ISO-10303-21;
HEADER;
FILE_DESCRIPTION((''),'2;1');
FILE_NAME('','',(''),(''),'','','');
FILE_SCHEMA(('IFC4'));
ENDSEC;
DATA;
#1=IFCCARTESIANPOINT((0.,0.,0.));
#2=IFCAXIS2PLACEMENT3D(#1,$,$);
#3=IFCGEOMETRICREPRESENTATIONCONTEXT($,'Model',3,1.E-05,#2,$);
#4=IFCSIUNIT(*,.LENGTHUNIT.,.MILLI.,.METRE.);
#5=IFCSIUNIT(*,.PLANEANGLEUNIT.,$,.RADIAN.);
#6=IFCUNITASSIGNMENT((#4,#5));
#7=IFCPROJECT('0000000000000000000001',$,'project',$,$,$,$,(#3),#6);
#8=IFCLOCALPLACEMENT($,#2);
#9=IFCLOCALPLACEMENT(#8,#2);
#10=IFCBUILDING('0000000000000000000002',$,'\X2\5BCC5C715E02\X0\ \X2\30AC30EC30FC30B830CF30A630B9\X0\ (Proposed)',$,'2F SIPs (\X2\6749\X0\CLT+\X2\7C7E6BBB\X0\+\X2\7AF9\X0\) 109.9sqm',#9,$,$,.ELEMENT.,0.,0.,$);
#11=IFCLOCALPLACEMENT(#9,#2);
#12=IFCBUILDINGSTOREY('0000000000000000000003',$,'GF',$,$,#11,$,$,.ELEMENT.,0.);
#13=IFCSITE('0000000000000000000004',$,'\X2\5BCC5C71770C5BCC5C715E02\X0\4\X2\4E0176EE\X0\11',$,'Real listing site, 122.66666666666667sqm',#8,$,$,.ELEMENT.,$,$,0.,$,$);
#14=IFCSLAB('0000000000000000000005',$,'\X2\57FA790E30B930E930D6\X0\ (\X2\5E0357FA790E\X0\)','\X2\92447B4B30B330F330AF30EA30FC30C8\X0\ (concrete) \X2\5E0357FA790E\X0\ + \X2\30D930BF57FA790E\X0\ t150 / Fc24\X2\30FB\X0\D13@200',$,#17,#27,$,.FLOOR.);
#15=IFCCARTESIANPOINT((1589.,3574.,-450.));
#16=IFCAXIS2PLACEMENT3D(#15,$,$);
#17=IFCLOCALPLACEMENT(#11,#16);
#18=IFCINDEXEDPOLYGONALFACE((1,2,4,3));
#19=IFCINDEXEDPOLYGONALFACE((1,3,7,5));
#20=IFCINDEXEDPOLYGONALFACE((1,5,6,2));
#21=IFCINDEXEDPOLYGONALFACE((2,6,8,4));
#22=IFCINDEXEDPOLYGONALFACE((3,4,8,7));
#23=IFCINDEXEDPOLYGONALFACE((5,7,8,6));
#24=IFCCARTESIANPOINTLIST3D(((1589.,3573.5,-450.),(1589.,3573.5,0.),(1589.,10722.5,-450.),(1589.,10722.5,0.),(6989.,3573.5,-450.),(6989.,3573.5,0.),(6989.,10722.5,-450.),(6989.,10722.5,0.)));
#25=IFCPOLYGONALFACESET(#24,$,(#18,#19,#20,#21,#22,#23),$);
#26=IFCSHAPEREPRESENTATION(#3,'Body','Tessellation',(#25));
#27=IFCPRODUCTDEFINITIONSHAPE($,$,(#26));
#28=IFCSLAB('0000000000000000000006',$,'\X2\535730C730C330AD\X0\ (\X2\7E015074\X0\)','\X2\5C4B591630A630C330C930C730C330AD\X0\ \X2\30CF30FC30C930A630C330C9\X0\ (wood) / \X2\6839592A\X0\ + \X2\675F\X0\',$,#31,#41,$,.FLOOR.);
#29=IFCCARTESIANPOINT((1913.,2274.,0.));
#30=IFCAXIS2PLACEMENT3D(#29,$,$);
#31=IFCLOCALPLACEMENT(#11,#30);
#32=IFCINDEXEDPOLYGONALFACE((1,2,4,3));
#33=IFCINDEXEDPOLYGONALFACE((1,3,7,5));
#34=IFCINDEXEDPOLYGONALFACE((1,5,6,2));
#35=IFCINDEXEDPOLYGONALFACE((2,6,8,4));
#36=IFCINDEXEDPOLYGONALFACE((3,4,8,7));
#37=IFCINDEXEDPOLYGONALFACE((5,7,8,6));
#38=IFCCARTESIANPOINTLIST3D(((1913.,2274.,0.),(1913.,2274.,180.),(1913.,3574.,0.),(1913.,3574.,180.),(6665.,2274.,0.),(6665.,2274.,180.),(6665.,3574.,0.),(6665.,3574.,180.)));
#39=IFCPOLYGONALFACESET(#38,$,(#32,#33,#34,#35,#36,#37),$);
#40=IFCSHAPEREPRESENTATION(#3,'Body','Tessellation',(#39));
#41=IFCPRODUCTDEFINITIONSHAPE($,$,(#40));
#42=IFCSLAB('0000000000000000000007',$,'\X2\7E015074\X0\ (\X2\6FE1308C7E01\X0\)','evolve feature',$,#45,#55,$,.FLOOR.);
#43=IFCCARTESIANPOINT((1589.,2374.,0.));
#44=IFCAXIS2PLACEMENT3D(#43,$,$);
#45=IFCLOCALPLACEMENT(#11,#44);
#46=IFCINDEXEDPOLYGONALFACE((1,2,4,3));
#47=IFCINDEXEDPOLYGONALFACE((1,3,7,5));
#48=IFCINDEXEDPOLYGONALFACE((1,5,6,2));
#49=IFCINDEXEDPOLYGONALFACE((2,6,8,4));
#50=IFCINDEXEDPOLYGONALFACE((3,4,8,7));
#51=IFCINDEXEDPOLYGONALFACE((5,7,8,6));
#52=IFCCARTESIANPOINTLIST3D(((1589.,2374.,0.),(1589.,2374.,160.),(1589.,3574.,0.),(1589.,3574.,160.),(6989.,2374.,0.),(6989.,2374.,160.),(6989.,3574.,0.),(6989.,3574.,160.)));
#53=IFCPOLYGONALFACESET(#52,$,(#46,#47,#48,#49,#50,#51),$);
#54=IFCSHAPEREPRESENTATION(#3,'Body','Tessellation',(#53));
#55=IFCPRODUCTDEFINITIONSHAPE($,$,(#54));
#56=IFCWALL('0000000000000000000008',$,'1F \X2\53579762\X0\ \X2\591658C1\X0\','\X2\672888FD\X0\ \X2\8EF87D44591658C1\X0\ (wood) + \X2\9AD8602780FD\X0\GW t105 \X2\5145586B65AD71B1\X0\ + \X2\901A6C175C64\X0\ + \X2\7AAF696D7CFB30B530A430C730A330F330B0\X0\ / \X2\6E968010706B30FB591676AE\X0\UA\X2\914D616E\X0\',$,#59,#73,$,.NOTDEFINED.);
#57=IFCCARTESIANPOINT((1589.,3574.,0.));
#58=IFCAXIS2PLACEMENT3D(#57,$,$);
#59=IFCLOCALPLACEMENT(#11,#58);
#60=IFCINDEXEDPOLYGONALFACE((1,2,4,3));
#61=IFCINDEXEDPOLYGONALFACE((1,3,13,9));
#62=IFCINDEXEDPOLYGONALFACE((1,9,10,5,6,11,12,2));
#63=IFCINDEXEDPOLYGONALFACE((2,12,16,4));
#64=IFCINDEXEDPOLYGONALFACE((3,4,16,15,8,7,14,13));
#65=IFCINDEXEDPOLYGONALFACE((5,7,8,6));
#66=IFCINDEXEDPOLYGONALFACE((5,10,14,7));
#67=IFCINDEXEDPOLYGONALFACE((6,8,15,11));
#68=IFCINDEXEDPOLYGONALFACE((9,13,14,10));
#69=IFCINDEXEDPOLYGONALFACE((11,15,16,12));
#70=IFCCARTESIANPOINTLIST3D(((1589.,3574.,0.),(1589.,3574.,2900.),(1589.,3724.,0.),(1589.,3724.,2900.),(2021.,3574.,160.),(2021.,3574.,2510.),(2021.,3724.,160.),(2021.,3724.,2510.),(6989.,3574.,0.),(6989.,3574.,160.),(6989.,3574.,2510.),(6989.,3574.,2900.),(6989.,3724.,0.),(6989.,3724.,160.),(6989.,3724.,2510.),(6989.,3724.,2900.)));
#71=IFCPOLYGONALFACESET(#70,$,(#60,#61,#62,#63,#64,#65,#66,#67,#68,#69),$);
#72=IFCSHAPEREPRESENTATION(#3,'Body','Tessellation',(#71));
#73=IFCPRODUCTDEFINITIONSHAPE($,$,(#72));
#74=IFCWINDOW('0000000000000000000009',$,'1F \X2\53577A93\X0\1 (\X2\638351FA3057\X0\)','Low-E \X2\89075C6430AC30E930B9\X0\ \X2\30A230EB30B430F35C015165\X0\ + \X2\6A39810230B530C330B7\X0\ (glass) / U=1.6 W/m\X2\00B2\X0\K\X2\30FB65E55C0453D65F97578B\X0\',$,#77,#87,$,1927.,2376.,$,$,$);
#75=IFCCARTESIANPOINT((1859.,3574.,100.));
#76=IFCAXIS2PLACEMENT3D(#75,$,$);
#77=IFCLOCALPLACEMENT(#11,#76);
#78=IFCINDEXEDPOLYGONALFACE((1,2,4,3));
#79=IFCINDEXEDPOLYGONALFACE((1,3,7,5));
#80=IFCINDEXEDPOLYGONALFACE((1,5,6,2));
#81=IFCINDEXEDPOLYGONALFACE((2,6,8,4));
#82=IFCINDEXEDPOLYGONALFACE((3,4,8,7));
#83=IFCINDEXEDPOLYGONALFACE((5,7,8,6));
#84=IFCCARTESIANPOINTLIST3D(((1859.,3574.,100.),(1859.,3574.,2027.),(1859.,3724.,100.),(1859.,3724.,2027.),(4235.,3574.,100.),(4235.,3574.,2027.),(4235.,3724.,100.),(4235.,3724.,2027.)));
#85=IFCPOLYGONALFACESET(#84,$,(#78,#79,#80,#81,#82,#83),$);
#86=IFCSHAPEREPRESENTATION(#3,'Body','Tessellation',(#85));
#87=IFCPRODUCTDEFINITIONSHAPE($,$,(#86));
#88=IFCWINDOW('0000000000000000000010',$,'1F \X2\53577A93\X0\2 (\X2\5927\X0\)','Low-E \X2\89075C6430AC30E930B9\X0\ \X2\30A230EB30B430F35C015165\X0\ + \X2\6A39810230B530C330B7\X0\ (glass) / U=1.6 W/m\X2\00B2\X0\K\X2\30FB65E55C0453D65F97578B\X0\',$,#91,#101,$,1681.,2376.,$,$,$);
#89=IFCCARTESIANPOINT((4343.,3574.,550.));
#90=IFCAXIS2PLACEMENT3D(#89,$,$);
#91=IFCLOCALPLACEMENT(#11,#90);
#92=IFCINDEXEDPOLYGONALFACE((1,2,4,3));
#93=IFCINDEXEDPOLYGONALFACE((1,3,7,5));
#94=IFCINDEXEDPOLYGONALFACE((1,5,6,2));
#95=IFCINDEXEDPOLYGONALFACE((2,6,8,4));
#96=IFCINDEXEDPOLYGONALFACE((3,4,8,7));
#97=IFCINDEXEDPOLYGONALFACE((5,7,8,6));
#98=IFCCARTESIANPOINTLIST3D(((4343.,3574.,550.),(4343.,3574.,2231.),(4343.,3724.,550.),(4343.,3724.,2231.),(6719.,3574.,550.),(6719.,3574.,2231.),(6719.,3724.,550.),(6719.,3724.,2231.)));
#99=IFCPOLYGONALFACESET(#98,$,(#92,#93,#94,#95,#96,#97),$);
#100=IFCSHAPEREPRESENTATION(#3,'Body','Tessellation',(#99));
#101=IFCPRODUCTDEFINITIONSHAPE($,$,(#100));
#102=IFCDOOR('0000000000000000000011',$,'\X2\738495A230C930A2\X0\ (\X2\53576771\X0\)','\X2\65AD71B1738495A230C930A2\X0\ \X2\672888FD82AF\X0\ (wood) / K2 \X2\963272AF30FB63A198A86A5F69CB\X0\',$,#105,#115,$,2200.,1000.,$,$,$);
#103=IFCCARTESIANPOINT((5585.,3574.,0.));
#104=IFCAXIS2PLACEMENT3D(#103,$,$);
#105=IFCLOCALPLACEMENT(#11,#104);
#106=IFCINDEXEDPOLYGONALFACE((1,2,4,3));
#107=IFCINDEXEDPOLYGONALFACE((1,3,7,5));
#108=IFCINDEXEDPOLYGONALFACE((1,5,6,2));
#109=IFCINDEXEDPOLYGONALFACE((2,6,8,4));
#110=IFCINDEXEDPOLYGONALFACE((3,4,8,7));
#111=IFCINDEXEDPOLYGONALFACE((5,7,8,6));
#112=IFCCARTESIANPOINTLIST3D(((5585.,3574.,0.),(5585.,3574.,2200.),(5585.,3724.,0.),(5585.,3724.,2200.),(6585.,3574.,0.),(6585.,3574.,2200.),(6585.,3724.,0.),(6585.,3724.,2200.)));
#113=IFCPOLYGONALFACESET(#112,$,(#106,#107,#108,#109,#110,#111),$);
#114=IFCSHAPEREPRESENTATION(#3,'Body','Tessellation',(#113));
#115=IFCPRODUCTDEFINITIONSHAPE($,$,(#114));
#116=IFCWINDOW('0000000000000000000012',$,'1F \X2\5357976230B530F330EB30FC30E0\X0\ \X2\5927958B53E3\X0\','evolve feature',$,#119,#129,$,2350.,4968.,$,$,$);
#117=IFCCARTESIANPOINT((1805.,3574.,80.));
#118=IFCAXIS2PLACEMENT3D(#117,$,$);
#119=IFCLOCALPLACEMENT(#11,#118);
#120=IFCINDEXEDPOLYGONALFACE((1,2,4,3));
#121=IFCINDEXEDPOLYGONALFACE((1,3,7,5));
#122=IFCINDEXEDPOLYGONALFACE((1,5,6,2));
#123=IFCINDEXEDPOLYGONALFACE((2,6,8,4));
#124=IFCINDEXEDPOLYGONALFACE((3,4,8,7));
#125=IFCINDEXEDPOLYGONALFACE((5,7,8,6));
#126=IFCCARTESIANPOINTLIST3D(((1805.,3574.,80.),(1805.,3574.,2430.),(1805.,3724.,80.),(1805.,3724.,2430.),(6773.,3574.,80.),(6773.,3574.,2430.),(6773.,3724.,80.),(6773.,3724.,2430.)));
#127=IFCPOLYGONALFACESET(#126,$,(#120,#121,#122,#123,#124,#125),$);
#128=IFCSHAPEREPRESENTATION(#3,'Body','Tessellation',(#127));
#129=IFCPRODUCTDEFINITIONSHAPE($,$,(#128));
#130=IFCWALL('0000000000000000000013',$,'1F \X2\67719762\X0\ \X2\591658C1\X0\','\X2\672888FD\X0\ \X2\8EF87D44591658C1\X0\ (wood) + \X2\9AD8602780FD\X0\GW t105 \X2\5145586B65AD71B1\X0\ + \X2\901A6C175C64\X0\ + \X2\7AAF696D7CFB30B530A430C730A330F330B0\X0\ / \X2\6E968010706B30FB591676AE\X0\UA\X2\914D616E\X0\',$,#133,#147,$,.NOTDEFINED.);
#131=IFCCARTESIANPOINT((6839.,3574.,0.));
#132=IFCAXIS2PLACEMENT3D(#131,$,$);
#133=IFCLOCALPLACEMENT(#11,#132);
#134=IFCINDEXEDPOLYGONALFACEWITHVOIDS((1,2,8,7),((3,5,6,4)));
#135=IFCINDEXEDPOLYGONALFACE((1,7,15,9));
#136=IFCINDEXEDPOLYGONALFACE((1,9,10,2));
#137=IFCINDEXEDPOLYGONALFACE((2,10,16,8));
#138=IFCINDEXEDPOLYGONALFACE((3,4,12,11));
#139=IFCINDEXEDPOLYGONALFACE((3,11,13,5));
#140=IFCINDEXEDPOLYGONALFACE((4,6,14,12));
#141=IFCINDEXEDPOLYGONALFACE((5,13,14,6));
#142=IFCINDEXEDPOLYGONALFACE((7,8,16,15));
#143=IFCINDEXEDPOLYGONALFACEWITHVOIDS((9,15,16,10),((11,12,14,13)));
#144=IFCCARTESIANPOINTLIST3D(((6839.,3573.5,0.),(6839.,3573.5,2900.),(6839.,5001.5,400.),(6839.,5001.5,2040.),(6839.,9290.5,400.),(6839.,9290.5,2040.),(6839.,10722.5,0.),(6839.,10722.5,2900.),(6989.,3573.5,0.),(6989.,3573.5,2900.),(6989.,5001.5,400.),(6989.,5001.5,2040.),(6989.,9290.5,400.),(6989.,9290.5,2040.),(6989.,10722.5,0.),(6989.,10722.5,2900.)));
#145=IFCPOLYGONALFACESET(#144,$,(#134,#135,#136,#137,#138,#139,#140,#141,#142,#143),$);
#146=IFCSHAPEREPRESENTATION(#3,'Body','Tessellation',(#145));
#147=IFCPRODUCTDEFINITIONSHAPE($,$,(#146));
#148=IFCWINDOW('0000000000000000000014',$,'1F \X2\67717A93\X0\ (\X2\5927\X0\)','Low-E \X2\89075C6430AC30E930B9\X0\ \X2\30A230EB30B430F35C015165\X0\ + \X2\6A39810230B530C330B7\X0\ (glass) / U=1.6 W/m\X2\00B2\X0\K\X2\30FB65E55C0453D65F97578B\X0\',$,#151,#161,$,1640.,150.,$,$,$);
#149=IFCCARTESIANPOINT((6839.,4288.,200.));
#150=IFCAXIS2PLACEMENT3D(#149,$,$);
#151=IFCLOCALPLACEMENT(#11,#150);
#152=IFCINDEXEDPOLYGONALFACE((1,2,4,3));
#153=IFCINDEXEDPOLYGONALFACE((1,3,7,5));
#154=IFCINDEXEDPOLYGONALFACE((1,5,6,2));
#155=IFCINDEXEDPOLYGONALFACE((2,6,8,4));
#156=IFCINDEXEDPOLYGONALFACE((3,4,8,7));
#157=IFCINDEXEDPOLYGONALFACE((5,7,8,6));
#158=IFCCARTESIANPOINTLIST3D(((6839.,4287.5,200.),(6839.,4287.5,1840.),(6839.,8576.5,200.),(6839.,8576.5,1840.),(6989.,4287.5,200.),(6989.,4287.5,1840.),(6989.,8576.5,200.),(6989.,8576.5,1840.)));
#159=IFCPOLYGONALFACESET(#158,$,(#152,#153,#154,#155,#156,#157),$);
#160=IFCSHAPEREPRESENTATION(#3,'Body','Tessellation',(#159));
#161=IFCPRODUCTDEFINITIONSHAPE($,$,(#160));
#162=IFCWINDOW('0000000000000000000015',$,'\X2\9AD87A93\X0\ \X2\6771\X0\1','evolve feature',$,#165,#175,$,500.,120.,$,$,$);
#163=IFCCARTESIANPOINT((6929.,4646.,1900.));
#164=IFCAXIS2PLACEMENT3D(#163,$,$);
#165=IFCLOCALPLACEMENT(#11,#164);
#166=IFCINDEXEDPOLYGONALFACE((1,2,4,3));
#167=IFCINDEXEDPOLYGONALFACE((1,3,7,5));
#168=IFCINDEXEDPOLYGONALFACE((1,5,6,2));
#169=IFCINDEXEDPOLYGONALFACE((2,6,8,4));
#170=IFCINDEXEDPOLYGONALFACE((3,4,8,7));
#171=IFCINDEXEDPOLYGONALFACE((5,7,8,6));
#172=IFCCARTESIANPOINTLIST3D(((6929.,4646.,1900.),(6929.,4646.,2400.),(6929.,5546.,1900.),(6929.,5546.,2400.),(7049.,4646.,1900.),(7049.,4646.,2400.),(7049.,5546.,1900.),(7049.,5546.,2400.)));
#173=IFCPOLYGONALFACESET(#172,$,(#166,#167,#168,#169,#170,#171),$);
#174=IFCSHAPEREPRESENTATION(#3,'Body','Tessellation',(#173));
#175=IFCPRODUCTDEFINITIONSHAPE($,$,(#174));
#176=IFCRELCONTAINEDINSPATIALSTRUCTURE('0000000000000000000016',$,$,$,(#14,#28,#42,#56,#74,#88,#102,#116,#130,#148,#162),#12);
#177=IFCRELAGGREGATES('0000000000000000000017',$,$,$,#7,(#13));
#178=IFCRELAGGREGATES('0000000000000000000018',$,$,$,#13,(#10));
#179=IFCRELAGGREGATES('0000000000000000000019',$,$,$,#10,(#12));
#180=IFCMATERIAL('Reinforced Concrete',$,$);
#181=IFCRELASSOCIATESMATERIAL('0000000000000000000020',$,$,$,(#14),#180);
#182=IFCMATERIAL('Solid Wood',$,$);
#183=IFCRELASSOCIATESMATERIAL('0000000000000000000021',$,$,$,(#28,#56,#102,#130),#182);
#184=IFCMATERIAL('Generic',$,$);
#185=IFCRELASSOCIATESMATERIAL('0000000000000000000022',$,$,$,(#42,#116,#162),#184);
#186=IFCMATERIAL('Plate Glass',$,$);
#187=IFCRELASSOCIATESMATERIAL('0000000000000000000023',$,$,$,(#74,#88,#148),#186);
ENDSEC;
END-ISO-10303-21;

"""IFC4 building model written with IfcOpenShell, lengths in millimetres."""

from ifc_helpers import new_model, si_unit, frame, frame_2d, origin, place, context, project, spatial, rectangle, extrude, material, element, fill, save


model = new_model("IFC4")

# Units and contexts
model_context = context("Model", 3, precision=1e-05, world=origin())
ifc_project = project(units=[si_unit("LENGTHUNIT", "METRE", prefix="MILLI"), si_unit("PLANEANGLEUNIT", "RADIAN")], contexts=[model_context])

# Site, building, storey
site_placement = place(None, origin())
site = spatial("IfcSite", under=ifc_project, at=site_placement, Name="富山県富山市4丁目11", ObjectType="Real listing site, 122.66666666666667sqm", CompositionType="ELEMENT", RefElevation=0.0)
building_placement = place(site_placement, origin())
building = spatial("IfcBuilding", under=site, at=building_placement, Name="富山市 ガレージハウス (Proposed)", ObjectType="2F SIPs (杉CLT+籾殻+竹) 109.9sqm", CompositionType="ELEMENT", ElevationOfRefHeight=0.0, ElevationOfTerrain=0.0)
storey_placement = place(building_placement, origin())
storey = spatial("IfcBuildingStorey", under=building, at=storey_placement, Name="GF", CompositionType="ELEMENT", Elevation=0.0)

# Slabs
ifc_material_1 = material(Name="Reinforced Concrete")
slab_1_placement = place(storey_placement, frame((1589.0, 3574.0, -450.0)))
element("IfcSlab", 1, at=slab_1_placement, inside=storey, material=ifc_material_1, Name="基礎スラブ (布基礎)", Description="鉄筋コンクリート (concrete) 布基礎 + ベタ基礎 t150 / Fc24・D13@200", PredefinedType="FLOOR", context=model_context, shape_type="SweptSolid", body=[
    extrude(rectangle(XDim=5400.0, YDim=7149.0, at=frame_2d((2700.0, 3574.0))), frame((1589.0, 3574.0, -450.0)), (0.0, 0.0, 1.0), 450.0),
])
ifc_material_2 = material(Name="Solid Wood")
slab_2_placement = place(storey_placement, frame((1913.0, 2274.0, 0.0)))
element("IfcSlab", 2, at=slab_2_placement, inside=storey, material=ifc_material_2, Name="南デッキ (縁側)", Description="屋外ウッドデッキ ハードウッド (wood) / 根太 + 束", PredefinedType="FLOOR", context=model_context, shape_type="SweptSolid", body=[
    extrude(rectangle(XDim=4752.0, YDim=1300.0, at=frame_2d((2376.0, 650.0))), frame((1913.0, 2274.0, 0.0)), (0.0, 0.0, 1.0), 180.0),
])
ifc_material_3 = material(Name="Generic")
slab_3_placement = place(storey_placement, frame((1589.0, 2374.0, 0.0)))
element("IfcSlab", 3, at=slab_3_placement, inside=storey, material=ifc_material_3, Name="縁側 (濡れ縁)", Description="evolve feature", PredefinedType="FLOOR", context=model_context, shape_type="SweptSolid", body=[
    extrude(rectangle(XDim=5400.0, YDim=1200.0, at=frame_2d((2700.0, 600.0))), frame((1589.0, 2374.0, 0.0)), (0.0, 0.0, 1.0), 160.0),
])

# Wall, openings, windows, door
wall_1_placement = place(storey_placement, frame((1589.0, 3574.0, 0.0)))
wall_1 = element("IfcWall", 4, at=wall_1_placement, inside=storey, material=ifc_material_2, Name="1F 南面 外壁", Description="木製 軸組外壁 (wood) + 高性能GW t105 充填断熱 + 通気層 + 窯業系サイディング / 準耐火・外皮UA配慮", PredefinedType="NOTDEFINED", context=model_context, shape_type="SweptSolid", body=[
    extrude(rectangle(XDim=5400.0, YDim=150.0, at=frame_2d((2700.0, 75.0))), frame((1589.0, 3574.0, 0.0)), (0.0, 0.0, 1.0), 2900.0),
])
opening_1_placement = place(storey_placement, frame((1859.0, 3574.0, 100.0)))
opening_1 = element("IfcOpeningElement", 5, at=opening_1_placement, cuts=wall_1, PredefinedType="NOTDEFINED", context=model_context, shape_type="SweptSolid", body=[
    extrude(rectangle(XDim=2376.0, YDim=150.0, at=frame_2d((1188.0, 75.0))), frame((1859.0, 3574.0, 100.0)), (0.0, 0.0, 1.0), 1927.0),
])
opening_2_placement = place(storey_placement, frame((4343.0, 3574.0, 550.0)))
opening_2 = element("IfcOpeningElement", 6, at=opening_2_placement, cuts=wall_1, PredefinedType="NOTDEFINED", context=model_context, shape_type="SweptSolid", body=[
    extrude(rectangle(XDim=2376.0, YDim=150.0, at=frame_2d((1188.0, 75.0))), frame((4343.0, 3574.0, 550.0)), (0.0, 0.0, 1.0), 1681.0),
])
opening_3_placement = place(storey_placement, frame((5585.0, 3574.0, 0.0)))
opening_3 = element("IfcOpeningElement", 7, at=opening_3_placement, cuts=wall_1, PredefinedType="NOTDEFINED", context=model_context, shape_type="SweptSolid", body=[
    extrude(rectangle(XDim=1000.0, YDim=150.0, at=frame_2d((500.0, 75.0))), frame((5585.0, 3574.0, 0.0)), (0.0, 0.0, 1.0), 2200.0),
])
opening_4_placement = place(storey_placement, frame((1805.0, 3574.0, 80.0)))
opening_4 = element("IfcOpeningElement", 8, at=opening_4_placement, cuts=wall_1, PredefinedType="NOTDEFINED", context=model_context, shape_type="SweptSolid", body=[
    extrude(rectangle(XDim=4968.0, YDim=150.0, at=frame_2d((2484.0, 75.0))), frame((1805.0, 3574.0, 80.0)), (0.0, 0.0, 1.0), 2350.0),
])
ifc_material_4 = material(Name="Plate Glass")
window_1_placement = place(storey_placement, frame((1859.0, 3574.0, 100.0)))
window_1 = element("IfcWindow", 9, at=window_1_placement, inside=storey, material=ifc_material_4, Name="1F 南窓1 (掃出し)", Description="Low-E 複層ガラス アルゴン封入 + 樹脂サッシ (glass) / U=1.6 W/m²K・日射取得型", OverallHeight=1927.0, OverallWidth=2376.0, context=model_context, shape_type="SweptSolid", body=[
    extrude(rectangle(XDim=2376.0, YDim=150.0, at=frame_2d((1188.0, 75.0))), frame((1859.0, 3574.0, 100.0)), (0.0, 0.0, 1.0), 1927.0),
])
fill(opening_1, window_1)
window_2_placement = place(storey_placement, frame((4343.0, 3574.0, 550.0)))
window_2 = element("IfcWindow", 10, at=window_2_placement, inside=storey, material=ifc_material_4, Name="1F 南窓2 (大)", Description="Low-E 複層ガラス アルゴン封入 + 樹脂サッシ (glass) / U=1.6 W/m²K・日射取得型", OverallHeight=1681.0, OverallWidth=2376.0, context=model_context, shape_type="SweptSolid", body=[
    extrude(rectangle(XDim=2376.0, YDim=150.0, at=frame_2d((1188.0, 75.0))), frame((4343.0, 3574.0, 550.0)), (0.0, 0.0, 1.0), 1681.0),
])
fill(opening_2, window_2)
door_placement = place(storey_placement, frame((5585.0, 3574.0, 0.0)))
door = element("IfcDoor", 11, at=door_placement, inside=storey, material=ifc_material_2, Name="玄関ドア (南東)", Description="断熱玄関ドア 木製芯 (wood) / K2 防犯・採風機構", OverallHeight=2200.0, OverallWidth=1000.0, context=model_context, shape_type="SweptSolid", body=[
    extrude(rectangle(XDim=1000.0, YDim=150.0, at=frame_2d((500.0, 75.0))), frame((5585.0, 3574.0, 0.0)), (0.0, 0.0, 1.0), 2200.0),
])
fill(opening_3, door)
window_3_placement = place(storey_placement, frame((1805.0, 3574.0, 80.0)))
window_3 = element("IfcWindow", 12, at=window_3_placement, inside=storey, material=ifc_material_3, Name="1F 南面サンルーム 大開口", Description="evolve feature", OverallHeight=2350.0, OverallWidth=4968.0, context=model_context, shape_type="SweptSolid", body=[
    extrude(rectangle(XDim=4968.0, YDim=150.0, at=frame_2d((2484.0, 75.0))), frame((1805.0, 3574.0, 80.0)), (0.0, 0.0, 1.0), 2350.0),
])
fill(opening_4, window_3)

# Wall, openings, windows
wall_2_placement = place(storey_placement, frame((6839.0, 3574.0, 0.0)))
wall_2 = element("IfcWall", 13, at=wall_2_placement, inside=storey, material=ifc_material_2, Name="1F 東面 外壁", Description="木製 軸組外壁 (wood) + 高性能GW t105 充填断熱 + 通気層 + 窯業系サイディング / 準耐火・外皮UA配慮", PredefinedType="NOTDEFINED", context=model_context, shape_type="SweptSolid", body=[
    extrude(rectangle(XDim=150.0, YDim=7149.0, at=frame_2d((75.0, 3574.0))), frame((6839.0, 3574.0, 0.0)), (0.0, 0.0, 1.0), 2900.0),
])
opening_5_placement = place(storey_placement, frame((6839.0, 4288.0, 200.0)))
opening_5 = element("IfcOpeningElement", 14, at=opening_5_placement, cuts=wall_2, PredefinedType="NOTDEFINED", context=model_context, shape_type="SweptSolid", body=[
    extrude(rectangle(XDim=150.0, YDim=4289.0, at=frame_2d((75.0, 2144.0))), frame((6839.0, 4288.0, 200.0)), (0.0, 0.0, 1.0), 1640.0),
])
opening_6_placement = place(storey_placement, frame((6929.0, 4646.0, 1900.0)))
opening_6 = element("IfcOpeningElement", 15, at=opening_6_placement, cuts=wall_2, PredefinedType="NOTDEFINED", context=model_context, shape_type="SweptSolid", body=[
    extrude(rectangle(XDim=120.0, YDim=900.0, at=frame_2d((60.0, 450.0))), frame((6929.0, 4646.0, 1900.0)), (0.0, 0.0, 1.0), 500.0),
])
window_4_placement = place(storey_placement, frame((6839.0, 4288.0, 200.0)))
window_4 = element("IfcWindow", 16, at=window_4_placement, inside=storey, material=ifc_material_4, Name="1F 東窓 (大)", Description="Low-E 複層ガラス アルゴン封入 + 樹脂サッシ (glass) / U=1.6 W/m²K・日射取得型", OverallHeight=1640.0, OverallWidth=150.0, context=model_context, shape_type="SweptSolid", body=[
    extrude(rectangle(XDim=150.0, YDim=4289.0, at=frame_2d((75.0, 2144.0))), frame((6839.0, 4288.0, 200.0)), (0.0, 0.0, 1.0), 1640.0),
])
fill(opening_5, window_4)
window_5_placement = place(storey_placement, frame((6929.0, 4646.0, 1900.0)))
window_5 = element("IfcWindow", 17, at=window_5_placement, inside=storey, material=ifc_material_3, Name="高窓 東1", Description="evolve feature", OverallHeight=500.0, OverallWidth=120.0, context=model_context, shape_type="SweptSolid", body=[
    extrude(rectangle(XDim=120.0, YDim=900.0, at=frame_2d((60.0, 450.0))), frame((6929.0, 4646.0, 1900.0)), (0.0, 0.0, 1.0), 500.0),
])
fill(opening_6, window_5)

save(model, "model.ifc")
